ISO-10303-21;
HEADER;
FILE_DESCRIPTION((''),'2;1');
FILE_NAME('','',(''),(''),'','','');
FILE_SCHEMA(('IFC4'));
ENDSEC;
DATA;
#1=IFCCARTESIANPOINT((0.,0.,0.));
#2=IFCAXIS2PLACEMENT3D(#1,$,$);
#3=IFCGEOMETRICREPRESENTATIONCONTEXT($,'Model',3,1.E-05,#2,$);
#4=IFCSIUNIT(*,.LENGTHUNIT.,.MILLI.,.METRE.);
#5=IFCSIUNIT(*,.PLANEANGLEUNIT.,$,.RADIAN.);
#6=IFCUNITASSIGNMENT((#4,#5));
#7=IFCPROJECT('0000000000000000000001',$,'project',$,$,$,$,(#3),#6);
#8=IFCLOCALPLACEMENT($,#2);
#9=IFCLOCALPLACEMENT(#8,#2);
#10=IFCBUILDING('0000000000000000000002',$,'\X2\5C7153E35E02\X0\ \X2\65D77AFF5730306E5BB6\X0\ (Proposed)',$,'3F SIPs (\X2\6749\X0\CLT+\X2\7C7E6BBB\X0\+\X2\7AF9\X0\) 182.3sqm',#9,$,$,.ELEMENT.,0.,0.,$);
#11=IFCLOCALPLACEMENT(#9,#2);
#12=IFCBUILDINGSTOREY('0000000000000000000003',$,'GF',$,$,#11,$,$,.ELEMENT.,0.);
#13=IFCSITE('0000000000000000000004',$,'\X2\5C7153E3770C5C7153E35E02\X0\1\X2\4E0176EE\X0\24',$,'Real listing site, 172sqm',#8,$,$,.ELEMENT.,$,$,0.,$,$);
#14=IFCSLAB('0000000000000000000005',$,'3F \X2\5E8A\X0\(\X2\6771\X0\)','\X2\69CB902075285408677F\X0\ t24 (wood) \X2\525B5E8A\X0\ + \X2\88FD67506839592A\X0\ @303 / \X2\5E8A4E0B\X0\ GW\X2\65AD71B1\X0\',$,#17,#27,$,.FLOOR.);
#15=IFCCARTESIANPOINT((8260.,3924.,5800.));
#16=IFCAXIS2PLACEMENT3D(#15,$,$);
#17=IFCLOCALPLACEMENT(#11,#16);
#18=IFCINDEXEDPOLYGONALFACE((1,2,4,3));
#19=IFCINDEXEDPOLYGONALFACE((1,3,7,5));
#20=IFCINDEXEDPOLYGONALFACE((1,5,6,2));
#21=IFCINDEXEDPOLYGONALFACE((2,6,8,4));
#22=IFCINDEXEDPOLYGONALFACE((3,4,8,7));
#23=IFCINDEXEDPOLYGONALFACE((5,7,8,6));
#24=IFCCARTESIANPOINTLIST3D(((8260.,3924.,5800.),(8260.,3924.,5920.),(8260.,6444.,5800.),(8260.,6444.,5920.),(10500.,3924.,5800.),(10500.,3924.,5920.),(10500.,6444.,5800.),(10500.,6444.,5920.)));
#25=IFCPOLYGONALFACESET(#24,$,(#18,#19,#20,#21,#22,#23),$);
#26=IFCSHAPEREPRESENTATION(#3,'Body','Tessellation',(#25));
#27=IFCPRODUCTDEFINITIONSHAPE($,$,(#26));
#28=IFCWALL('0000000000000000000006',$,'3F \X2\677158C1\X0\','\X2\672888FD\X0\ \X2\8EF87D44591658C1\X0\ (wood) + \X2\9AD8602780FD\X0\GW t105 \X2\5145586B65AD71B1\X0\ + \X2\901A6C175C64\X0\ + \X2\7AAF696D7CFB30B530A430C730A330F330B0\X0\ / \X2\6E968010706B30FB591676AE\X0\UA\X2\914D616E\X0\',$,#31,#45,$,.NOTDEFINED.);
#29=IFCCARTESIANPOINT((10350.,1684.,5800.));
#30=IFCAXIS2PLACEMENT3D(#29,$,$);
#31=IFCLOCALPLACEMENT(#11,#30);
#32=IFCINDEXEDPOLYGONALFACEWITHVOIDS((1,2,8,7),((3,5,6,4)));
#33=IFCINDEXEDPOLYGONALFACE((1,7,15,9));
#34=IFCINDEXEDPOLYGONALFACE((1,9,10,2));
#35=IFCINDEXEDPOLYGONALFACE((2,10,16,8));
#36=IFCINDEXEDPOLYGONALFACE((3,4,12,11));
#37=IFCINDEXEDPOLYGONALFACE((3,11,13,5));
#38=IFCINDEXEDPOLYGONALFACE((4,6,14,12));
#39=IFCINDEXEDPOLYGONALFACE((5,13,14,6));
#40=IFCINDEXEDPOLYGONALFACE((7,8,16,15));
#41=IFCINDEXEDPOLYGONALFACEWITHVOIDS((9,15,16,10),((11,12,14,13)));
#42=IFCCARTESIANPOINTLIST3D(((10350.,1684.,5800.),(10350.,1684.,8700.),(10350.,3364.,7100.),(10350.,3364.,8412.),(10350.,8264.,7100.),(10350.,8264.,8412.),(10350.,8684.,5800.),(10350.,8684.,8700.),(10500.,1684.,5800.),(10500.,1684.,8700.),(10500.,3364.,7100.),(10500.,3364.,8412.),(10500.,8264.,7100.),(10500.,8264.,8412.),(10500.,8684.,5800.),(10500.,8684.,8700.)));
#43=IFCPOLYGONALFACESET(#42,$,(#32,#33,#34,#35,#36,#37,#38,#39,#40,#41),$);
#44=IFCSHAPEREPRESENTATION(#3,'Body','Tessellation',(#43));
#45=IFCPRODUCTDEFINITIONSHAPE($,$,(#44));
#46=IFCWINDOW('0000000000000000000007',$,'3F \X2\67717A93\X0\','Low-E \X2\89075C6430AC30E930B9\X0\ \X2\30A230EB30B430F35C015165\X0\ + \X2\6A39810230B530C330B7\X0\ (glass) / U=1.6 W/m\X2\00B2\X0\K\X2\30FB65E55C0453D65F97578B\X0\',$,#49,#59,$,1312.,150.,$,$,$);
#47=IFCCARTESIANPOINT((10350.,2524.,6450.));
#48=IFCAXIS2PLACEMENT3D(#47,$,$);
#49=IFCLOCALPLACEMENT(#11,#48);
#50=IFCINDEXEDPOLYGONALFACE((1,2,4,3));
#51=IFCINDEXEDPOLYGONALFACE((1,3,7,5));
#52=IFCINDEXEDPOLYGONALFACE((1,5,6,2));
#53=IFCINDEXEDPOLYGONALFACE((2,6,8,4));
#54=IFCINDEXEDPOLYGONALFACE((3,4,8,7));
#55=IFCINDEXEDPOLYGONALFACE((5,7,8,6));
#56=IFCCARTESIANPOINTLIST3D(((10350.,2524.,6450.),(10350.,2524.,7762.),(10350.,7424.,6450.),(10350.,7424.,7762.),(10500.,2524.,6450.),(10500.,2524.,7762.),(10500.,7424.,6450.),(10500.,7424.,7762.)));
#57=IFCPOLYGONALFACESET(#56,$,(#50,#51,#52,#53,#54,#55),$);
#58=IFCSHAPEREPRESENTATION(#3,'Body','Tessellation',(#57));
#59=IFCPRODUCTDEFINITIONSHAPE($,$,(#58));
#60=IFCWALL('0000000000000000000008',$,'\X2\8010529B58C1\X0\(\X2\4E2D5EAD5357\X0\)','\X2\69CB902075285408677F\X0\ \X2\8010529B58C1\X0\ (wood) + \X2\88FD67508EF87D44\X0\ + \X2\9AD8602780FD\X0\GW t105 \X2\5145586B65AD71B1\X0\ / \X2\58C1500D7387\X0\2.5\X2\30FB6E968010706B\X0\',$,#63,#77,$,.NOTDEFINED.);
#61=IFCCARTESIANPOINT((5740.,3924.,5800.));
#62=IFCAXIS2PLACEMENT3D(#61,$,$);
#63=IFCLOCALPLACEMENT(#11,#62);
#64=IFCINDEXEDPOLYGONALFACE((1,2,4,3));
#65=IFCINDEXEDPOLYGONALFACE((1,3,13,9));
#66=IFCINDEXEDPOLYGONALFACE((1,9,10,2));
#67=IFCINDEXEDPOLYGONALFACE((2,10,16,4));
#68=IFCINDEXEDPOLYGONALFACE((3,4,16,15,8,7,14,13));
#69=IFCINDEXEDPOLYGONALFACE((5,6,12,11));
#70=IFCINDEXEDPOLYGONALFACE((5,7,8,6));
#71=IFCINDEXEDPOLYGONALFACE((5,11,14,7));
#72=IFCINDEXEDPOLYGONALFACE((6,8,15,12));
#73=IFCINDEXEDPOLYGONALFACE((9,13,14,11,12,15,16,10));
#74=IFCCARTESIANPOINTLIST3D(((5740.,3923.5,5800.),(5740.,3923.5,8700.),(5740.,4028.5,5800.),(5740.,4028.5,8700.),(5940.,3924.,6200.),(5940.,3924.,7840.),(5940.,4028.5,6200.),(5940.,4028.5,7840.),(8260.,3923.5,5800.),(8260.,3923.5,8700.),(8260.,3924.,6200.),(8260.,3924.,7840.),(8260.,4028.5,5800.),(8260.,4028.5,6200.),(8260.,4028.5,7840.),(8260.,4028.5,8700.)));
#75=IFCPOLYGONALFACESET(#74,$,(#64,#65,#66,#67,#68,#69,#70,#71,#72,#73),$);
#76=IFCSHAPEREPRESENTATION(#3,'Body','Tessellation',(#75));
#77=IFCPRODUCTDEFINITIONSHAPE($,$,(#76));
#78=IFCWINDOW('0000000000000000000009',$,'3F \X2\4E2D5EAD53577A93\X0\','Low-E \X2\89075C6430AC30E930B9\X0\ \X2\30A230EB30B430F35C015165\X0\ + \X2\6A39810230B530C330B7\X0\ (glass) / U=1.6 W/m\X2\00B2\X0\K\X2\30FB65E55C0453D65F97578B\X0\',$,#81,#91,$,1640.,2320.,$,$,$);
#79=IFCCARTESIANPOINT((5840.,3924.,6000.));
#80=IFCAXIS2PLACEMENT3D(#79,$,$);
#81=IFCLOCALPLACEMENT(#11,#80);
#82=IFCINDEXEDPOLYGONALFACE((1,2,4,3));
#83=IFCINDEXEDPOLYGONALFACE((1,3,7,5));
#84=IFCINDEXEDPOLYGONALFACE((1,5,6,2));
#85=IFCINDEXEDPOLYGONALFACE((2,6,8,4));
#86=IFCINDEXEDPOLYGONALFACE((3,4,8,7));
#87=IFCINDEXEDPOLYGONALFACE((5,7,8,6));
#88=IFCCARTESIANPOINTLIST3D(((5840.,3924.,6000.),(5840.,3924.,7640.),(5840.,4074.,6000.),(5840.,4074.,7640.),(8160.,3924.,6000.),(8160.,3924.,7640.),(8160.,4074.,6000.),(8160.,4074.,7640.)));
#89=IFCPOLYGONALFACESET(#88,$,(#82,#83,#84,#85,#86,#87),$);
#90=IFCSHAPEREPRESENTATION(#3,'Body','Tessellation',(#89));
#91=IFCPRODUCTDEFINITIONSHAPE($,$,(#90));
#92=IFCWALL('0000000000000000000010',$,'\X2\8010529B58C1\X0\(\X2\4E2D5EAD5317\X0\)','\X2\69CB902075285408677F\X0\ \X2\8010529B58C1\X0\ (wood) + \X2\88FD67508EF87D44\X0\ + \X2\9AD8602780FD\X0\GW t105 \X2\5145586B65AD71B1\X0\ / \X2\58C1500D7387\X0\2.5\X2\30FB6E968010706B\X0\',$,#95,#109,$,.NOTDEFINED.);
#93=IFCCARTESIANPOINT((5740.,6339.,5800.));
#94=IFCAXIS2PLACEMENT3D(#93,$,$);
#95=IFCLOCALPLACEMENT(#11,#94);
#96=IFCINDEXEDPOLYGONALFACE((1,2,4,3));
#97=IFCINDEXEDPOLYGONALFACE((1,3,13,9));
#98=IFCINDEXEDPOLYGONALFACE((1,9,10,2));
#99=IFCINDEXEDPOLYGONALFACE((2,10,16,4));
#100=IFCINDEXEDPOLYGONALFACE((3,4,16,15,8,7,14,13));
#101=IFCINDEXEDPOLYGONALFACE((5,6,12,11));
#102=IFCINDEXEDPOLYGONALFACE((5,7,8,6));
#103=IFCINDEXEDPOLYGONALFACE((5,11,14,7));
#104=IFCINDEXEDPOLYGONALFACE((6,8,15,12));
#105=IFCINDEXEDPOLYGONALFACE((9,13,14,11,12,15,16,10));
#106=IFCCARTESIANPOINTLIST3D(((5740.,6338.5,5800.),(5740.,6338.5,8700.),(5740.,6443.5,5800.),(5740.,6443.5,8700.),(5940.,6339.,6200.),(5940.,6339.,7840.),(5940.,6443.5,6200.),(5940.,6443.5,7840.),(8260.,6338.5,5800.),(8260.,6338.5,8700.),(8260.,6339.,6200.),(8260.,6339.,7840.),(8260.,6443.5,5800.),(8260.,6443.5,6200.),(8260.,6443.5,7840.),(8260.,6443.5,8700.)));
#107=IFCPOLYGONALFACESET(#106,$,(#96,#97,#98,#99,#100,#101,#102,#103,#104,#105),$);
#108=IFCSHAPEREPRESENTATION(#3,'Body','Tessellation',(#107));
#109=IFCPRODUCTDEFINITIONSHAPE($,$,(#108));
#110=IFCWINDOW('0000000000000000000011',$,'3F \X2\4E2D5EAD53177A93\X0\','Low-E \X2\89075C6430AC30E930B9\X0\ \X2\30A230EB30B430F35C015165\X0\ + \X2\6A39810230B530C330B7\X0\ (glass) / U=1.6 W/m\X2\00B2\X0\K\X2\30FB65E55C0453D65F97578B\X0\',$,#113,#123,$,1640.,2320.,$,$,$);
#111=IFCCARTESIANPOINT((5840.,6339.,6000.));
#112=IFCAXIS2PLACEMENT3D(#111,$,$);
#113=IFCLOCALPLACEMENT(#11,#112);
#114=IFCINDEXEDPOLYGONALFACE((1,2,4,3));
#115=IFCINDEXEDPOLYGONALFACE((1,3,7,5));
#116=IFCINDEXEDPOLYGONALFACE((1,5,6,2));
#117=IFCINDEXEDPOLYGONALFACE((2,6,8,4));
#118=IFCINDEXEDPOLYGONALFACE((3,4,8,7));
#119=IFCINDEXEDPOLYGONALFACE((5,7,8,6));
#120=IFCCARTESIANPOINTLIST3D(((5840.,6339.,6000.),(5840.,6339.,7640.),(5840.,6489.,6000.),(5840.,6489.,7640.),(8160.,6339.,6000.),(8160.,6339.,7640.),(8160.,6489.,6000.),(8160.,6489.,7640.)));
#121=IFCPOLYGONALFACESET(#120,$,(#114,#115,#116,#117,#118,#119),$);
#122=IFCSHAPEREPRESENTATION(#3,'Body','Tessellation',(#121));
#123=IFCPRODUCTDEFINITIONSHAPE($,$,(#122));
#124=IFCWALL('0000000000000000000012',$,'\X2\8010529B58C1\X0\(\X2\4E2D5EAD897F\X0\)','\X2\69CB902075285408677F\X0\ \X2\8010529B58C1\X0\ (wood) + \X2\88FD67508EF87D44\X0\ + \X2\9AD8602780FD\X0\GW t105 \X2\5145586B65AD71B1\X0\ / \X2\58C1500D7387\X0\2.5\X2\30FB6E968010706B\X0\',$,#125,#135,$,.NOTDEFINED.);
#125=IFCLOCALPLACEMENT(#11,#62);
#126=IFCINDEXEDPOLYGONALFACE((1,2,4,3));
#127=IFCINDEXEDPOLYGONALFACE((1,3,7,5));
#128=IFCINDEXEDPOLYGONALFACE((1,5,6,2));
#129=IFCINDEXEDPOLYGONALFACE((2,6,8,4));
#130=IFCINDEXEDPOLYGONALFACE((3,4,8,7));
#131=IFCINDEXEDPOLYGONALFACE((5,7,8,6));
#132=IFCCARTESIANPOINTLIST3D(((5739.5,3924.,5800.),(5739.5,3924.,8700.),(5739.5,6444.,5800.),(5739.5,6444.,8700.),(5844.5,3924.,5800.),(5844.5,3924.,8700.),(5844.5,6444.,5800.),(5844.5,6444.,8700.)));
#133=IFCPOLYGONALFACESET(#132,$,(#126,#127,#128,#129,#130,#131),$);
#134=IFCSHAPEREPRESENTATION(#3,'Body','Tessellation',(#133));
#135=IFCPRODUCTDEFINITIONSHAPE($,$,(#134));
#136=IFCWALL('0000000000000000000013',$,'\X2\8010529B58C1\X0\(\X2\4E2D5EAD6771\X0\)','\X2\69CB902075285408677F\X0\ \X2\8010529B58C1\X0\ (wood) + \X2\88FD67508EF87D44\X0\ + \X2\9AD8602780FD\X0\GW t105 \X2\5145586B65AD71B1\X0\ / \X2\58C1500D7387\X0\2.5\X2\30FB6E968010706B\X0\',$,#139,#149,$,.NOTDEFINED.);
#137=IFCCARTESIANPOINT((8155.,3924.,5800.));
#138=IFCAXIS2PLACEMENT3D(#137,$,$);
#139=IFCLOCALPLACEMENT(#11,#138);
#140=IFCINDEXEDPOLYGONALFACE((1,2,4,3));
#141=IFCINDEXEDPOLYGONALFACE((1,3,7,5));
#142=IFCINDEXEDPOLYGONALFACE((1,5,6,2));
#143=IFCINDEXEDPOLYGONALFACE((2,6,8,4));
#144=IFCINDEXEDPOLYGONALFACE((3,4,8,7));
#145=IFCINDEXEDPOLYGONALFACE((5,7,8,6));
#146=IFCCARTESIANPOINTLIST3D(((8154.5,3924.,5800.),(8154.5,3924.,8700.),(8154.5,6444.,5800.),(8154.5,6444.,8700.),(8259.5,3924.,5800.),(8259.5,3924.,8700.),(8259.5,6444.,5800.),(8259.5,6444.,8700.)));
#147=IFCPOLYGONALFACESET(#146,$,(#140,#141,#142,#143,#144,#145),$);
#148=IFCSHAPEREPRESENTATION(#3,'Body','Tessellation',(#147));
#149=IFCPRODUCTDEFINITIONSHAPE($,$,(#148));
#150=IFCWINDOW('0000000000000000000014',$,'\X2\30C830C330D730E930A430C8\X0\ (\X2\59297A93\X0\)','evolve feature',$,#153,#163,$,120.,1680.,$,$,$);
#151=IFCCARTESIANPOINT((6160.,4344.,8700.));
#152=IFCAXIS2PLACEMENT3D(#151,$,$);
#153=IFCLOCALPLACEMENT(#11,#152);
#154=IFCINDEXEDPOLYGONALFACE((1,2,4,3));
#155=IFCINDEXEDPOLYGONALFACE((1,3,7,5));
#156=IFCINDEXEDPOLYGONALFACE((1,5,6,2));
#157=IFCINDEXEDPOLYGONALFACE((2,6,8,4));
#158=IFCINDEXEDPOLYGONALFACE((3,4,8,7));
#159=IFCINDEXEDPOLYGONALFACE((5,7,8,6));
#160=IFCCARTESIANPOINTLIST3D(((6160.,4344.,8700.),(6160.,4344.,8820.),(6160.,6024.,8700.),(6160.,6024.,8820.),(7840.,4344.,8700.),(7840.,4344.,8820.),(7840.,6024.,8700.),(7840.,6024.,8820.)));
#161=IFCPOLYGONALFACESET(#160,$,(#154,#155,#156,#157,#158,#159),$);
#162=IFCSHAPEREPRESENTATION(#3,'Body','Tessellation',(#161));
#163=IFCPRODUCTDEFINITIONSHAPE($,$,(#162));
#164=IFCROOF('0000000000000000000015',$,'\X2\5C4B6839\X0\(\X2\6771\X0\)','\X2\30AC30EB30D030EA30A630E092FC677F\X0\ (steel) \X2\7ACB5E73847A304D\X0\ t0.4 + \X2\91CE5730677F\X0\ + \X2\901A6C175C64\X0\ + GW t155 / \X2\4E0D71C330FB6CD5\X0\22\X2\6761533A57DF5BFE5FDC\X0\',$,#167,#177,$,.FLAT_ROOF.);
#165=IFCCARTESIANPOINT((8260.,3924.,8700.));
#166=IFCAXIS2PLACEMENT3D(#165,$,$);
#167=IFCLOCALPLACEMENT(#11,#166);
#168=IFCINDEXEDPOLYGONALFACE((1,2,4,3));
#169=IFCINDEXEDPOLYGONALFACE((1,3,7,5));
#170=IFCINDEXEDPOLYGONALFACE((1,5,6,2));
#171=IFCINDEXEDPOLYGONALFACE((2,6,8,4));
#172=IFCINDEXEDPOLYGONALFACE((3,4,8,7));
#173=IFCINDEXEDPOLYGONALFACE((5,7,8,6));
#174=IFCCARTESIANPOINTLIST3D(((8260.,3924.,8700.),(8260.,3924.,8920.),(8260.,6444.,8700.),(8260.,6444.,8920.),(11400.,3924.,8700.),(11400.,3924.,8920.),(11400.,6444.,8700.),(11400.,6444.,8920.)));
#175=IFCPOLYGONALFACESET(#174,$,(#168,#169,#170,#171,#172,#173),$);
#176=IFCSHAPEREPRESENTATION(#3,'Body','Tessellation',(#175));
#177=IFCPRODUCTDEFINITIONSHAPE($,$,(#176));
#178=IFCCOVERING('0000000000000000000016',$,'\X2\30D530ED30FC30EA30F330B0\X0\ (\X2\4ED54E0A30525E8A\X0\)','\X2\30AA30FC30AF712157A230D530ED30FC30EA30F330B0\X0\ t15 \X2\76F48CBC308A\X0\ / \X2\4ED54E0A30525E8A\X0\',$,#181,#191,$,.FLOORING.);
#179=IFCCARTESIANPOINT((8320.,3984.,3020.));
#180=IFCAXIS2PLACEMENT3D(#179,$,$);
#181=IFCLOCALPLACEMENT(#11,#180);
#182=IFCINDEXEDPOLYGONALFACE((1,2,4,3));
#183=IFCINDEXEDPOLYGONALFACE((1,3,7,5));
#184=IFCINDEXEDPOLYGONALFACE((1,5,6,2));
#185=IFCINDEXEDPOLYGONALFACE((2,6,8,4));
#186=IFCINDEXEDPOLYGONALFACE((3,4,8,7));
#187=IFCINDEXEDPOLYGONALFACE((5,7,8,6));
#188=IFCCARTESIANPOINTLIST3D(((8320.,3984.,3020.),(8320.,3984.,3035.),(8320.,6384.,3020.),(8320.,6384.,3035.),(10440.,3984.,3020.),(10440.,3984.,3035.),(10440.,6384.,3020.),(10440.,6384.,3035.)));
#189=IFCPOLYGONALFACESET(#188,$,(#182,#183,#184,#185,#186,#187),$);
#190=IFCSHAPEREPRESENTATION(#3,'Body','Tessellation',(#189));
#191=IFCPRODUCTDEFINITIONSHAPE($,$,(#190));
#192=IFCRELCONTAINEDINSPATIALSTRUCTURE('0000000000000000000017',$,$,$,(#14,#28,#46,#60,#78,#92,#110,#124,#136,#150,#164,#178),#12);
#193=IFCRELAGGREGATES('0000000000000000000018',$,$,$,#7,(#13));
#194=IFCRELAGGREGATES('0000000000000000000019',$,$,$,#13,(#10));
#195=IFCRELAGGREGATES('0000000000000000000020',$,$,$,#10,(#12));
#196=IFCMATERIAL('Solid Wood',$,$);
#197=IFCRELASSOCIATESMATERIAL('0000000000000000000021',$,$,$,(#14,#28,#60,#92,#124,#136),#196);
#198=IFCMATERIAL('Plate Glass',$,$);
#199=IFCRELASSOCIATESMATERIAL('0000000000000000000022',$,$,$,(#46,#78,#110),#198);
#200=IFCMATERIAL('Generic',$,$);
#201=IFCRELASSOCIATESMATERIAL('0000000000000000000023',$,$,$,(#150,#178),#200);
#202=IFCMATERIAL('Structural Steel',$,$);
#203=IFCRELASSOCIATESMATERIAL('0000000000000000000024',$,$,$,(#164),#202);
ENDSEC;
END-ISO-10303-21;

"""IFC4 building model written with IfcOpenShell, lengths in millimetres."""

from ifc_helpers import new_model, si_unit, frame, frame_2d, origin, place, context, project, spatial, rectangle, extrude, material, element, fill, save


model = new_model("IFC4")

# Units and contexts
model_context = context("Model", 3, precision=1e-05, world=origin())
ifc_project = project(units=[si_unit("LENGTHUNIT", "METRE", prefix="MILLI"), si_unit("PLANEANGLEUNIT", "RADIAN")], contexts=[model_context])

# Site, building, storey
site_placement = place(None, origin())
site = spatial("IfcSite", under=ifc_project, at=site_placement, Name="山口県山口市1丁目24", ObjectType="Real listing site, 172sqm", CompositionType="ELEMENT", RefElevation=0.0)
building_placement = place(site_placement, origin())
building = spatial("IfcBuilding", under=site, at=building_placement, Name="山口市 旗竿地の家 (Proposed)", ObjectType="3F SIPs (杉CLT+籾殻+竹) 182.3sqm", CompositionType="ELEMENT", ElevationOfRefHeight=0.0, ElevationOfTerrain=0.0)
storey_placement = place(building_placement, origin())
storey = spatial("IfcBuildingStorey", under=building, at=storey_placement, Name="GF", CompositionType="ELEMENT", Elevation=0.0)

# Slab
ifc_material_1 = material(Name="Solid Wood")
slab_placement = place(storey_placement, frame((8260.0, 3924.0, 5800.0)))
element("IfcSlab", 1, at=slab_placement, inside=storey, material=ifc_material_1, Name="3F 床(東)", Description="構造用合板 t24 (wood) 剛床 + 製材根太 @303 / 床下 GW断熱", PredefinedType="FLOOR", context=model_context, shape_type="SweptSolid", body=[
    extrude(rectangle(XDim=2240.0, YDim=2520.0, at=frame_2d((1120.0, 1260.0))), frame((8260.0, 3924.0, 5800.0)), (0.0, 0.0, 1.0), 120.0),
])

# Walls, openings, windows
wall_1_placement = place(storey_placement, frame((10350.0, 1684.0, 5800.0)))
wall_1 = element("IfcWall", 2, at=wall_1_placement, inside=storey, material=ifc_material_1, Name="3F 東壁", Description="木製 軸組外壁 (wood) + 高性能GW t105 充填断熱 + 通気層 + 窯業系サイディング / 準耐火・外皮UA配慮", PredefinedType="NOTDEFINED", context=model_context, shape_type="SweptSolid", body=[
    extrude(rectangle(XDim=150.0, YDim=7000.0, at=frame_2d((75.0, 3500.0))), frame((10350.0, 1684.0, 5800.0)), (0.0, 0.0, 1.0), 2900.0),
])
opening_1_placement = place(storey_placement, frame((10350.0, 2524.0, 6450.0)))
opening_1 = element("IfcOpeningElement", 3, at=opening_1_placement, cuts=wall_1, PredefinedType="NOTDEFINED", context=model_context, shape_type="SweptSolid", body=[
    extrude(rectangle(XDim=150.0, YDim=4900.0, at=frame_2d((75.0, 2450.0))), frame((10350.0, 2524.0, 6450.0)), (0.0, 0.0, 1.0), 1312.0),
])
ifc_material_2 = material(Name="Plate Glass")
window_1_placement = place(storey_placement, frame((10350.0, 2524.0, 6450.0)))
window_1 = element("IfcWindow", 4, at=window_1_placement, inside=storey, material=ifc_material_2, Name="3F 東窓", Description="Low-E 複層ガラス アルゴン封入 + 樹脂サッシ (glass) / U=1.6 W/m²K・日射取得型", OverallHeight=1312.0, OverallWidth=150.0, context=model_context, shape_type="SweptSolid", body=[
    extrude(rectangle(XDim=150.0, YDim=4900.0, at=frame_2d((75.0, 2450.0))), frame((10350.0, 2524.0, 6450.0)), (0.0, 0.0, 1.0), 1312.0),
])
fill(opening_1, window_1)
wall_2_placement = place(storey_placement, frame((5740.0, 3924.0, 5800.0)))
wall_2 = element("IfcWall", 5, at=wall_2_placement, inside=storey, material=ifc_material_1, Name="耐力壁(中庭南)", Description="構造用合板 耐力壁 (wood) + 製材軸組 + 高性能GW t105 充填断熱 / 壁倍率2.5・準耐火", PredefinedType="NOTDEFINED", context=model_context, shape_type="SweptSolid", body=[
    extrude(rectangle(XDim=2520.0, YDim=105.0, at=frame_2d((1260.0, 52.0))), frame((5740.0, 3924.0, 5800.0)), (0.0, 0.0, 1.0), 2900.0),
])
opening_2_placement = place(storey_placement, frame((5840.0, 3924.0, 6000.0)))
opening_2 = element("IfcOpeningElement", 6, at=opening_2_placement, cuts=wall_2, PredefinedType="NOTDEFINED", context=model_context, shape_type="SweptSolid", body=[
    extrude(rectangle(XDim=2320.0, YDim=150.0, at=frame_2d((1160.0, 75.0))), frame((5840.0, 3924.0, 6000.0)), (0.0, 0.0, 1.0), 1640.0),
])
window_2_placement = place(storey_placement, frame((5840.0, 3924.0, 6000.0)))
window_2 = element("IfcWindow", 7, at=window_2_placement, inside=storey, material=ifc_material_2, Name="3F 中庭南窓", Description="Low-E 複層ガラス アルゴン封入 + 樹脂サッシ (glass) / U=1.6 W/m²K・日射取得型", OverallHeight=1640.0, OverallWidth=2320.0, context=model_context, shape_type="SweptSolid", body=[
    extrude(rectangle(XDim=2320.0, YDim=150.0, at=frame_2d((1160.0, 75.0))), frame((5840.0, 3924.0, 6000.0)), (0.0, 0.0, 1.0), 1640.0),
])
fill(opening_2, window_2)
wall_3_placement = place(storey_placement, frame((5740.0, 6339.0, 5800.0)))
wall_3 = element("IfcWall", 8, at=wall_3_placement, inside=storey, material=ifc_material_1, Name="耐力壁(中庭北)", Description="構造用合板 耐力壁 (wood) + 製材軸組 + 高性能GW t105 充填断熱 / 壁倍率2.5・準耐火", PredefinedType="NOTDEFINED", context=model_context, shape_type="SweptSolid", body=[
    extrude(rectangle(XDim=2520.0, YDim=105.0, at=frame_2d((1260.0, 52.0))), frame((5740.0, 6339.0, 5800.0)), (0.0, 0.0, 1.0), 2900.0),
])
opening_3_placement = place(storey_placement, frame((5840.0, 6339.0, 6000.0)))
opening_3 = element("IfcOpeningElement", 9, at=opening_3_placement, cuts=wall_3, PredefinedType="NOTDEFINED", context=model_context, shape_type="SweptSolid", body=[
    extrude(rectangle(XDim=2320.0, YDim=150.0, at=frame_2d((1160.0, 75.0))), frame((5840.0, 6339.0, 6000.0)), (0.0, 0.0, 1.0), 1640.0),
])
window_3_placement = place(storey_placement, frame((5840.0, 6339.0, 6000.0)))
window_3 = element("IfcWindow", 10, at=window_3_placement, inside=storey, material=ifc_material_2, Name="3F 中庭北窓", Description="Low-E 複層ガラス アルゴン封入 + 樹脂サッシ (glass) / U=1.6 W/m²K・日射取得型", OverallHeight=1640.0, OverallWidth=2320.0, context=model_context, shape_type="SweptSolid", body=[
    extrude(rectangle(XDim=2320.0, YDim=150.0, at=frame_2d((1160.0, 75.0))), frame((5840.0, 6339.0, 6000.0)), (0.0, 0.0, 1.0), 1640.0),
])
fill(opening_3, window_3)

# Walls
wall_4_placement = place(storey_placement, frame((5740.0, 3924.0, 5800.0)))
element("IfcWall", 11, at=wall_4_placement, inside=storey, material=ifc_material_1, Name="耐力壁(中庭西)", Description="構造用合板 耐力壁 (wood) + 製材軸組 + 高性能GW t105 充填断熱 / 壁倍率2.5・準耐火", PredefinedType="NOTDEFINED", context=model_context, shape_type="SweptSolid", body=[
    extrude(rectangle(XDim=105.0, YDim=2520.0, at=frame_2d((52.0, 1260.0))), frame((5740.0, 3924.0, 5800.0)), (0.0, 0.0, 1.0), 2900.0),
])
wall_5_placement = place(storey_placement, frame((8155.0, 3924.0, 5800.0)))
element("IfcWall", 12, at=wall_5_placement, inside=storey, material=ifc_material_1, Name="耐力壁(中庭東)", Description="構造用合板 耐力壁 (wood) + 製材軸組 + 高性能GW t105 充填断熱 / 壁倍率2.5・準耐火", PredefinedType="NOTDEFINED", context=model_context, shape_type="SweptSolid", body=[
    extrude(rectangle(XDim=105.0, YDim=2520.0, at=frame_2d((52.0, 1260.0))), frame((8155.0, 3924.0, 5800.0)), (0.0, 0.0, 1.0), 2900.0),
])

# Window
ifc_material_3 = material(Name="Generic")
window_4_placement = place(storey_placement, frame((6160.0, 4344.0, 8700.0)))
element("IfcWindow", 13, at=window_4_placement, inside=storey, material=ifc_material_3, Name="トップライト (天窓)", Description="evolve feature", OverallHeight=120.0, OverallWidth=1680.0, context=model_context, shape_type="SweptSolid", body=[
    extrude(rectangle(XDim=1680.0, YDim=1680.0, at=frame_2d((840.0, 840.0))), frame((6160.0, 4344.0, 8700.0)), (0.0, 0.0, 1.0), 120.0),
])

# Roof
ifc_material_4 = material(Name="Structural Steel")
for number, where, name in (
    (14, (8260.0, 3924.0, 8700.0), "屋根(東)"),
):
    element("IfcRoof", number, at=place(storey_placement, frame(where)), inside=storey, material=ifc_material_4, Name=name, Description="ガルバリウム鋼板 (steel) 立平葺き t0.4 + 野地板 + 通気層 + GW t155 / 不燃・法22条区域対応", PredefinedType="FLAT_ROOF", context=model_context, shape_type="SweptSolid", body=[
        extrude(rectangle(XDim=3140.0, YDim=2520.0, at=frame_2d((1570.0, 1260.0))), frame((8260.0, 3924.0, 8700.0)), (0.0, 0.0, 1.0), 220.0),
    ])

# Covering
covering_1_placement = place(storey_placement, frame((8320.0, 3984.0, 3020.0)))
element("IfcCovering", 15, at=covering_1_placement, inside=storey, material=ifc_material_3, Name="フローリング (仕上げ床)", Description="オーク無垢フローリング t15 直貼り / 仕上げ床", PredefinedType="FLOORING", context=model_context, shape_type="SweptSolid", body=[
    extrude(rectangle(XDim=2120.0, YDim=2400.0, at=frame_2d((1060.0, 1200.0))), frame((8320.0, 3984.0, 3020.0)), (0.0, 0.0, 1.0), 15.0),
])

save(model, "model.ifc")
